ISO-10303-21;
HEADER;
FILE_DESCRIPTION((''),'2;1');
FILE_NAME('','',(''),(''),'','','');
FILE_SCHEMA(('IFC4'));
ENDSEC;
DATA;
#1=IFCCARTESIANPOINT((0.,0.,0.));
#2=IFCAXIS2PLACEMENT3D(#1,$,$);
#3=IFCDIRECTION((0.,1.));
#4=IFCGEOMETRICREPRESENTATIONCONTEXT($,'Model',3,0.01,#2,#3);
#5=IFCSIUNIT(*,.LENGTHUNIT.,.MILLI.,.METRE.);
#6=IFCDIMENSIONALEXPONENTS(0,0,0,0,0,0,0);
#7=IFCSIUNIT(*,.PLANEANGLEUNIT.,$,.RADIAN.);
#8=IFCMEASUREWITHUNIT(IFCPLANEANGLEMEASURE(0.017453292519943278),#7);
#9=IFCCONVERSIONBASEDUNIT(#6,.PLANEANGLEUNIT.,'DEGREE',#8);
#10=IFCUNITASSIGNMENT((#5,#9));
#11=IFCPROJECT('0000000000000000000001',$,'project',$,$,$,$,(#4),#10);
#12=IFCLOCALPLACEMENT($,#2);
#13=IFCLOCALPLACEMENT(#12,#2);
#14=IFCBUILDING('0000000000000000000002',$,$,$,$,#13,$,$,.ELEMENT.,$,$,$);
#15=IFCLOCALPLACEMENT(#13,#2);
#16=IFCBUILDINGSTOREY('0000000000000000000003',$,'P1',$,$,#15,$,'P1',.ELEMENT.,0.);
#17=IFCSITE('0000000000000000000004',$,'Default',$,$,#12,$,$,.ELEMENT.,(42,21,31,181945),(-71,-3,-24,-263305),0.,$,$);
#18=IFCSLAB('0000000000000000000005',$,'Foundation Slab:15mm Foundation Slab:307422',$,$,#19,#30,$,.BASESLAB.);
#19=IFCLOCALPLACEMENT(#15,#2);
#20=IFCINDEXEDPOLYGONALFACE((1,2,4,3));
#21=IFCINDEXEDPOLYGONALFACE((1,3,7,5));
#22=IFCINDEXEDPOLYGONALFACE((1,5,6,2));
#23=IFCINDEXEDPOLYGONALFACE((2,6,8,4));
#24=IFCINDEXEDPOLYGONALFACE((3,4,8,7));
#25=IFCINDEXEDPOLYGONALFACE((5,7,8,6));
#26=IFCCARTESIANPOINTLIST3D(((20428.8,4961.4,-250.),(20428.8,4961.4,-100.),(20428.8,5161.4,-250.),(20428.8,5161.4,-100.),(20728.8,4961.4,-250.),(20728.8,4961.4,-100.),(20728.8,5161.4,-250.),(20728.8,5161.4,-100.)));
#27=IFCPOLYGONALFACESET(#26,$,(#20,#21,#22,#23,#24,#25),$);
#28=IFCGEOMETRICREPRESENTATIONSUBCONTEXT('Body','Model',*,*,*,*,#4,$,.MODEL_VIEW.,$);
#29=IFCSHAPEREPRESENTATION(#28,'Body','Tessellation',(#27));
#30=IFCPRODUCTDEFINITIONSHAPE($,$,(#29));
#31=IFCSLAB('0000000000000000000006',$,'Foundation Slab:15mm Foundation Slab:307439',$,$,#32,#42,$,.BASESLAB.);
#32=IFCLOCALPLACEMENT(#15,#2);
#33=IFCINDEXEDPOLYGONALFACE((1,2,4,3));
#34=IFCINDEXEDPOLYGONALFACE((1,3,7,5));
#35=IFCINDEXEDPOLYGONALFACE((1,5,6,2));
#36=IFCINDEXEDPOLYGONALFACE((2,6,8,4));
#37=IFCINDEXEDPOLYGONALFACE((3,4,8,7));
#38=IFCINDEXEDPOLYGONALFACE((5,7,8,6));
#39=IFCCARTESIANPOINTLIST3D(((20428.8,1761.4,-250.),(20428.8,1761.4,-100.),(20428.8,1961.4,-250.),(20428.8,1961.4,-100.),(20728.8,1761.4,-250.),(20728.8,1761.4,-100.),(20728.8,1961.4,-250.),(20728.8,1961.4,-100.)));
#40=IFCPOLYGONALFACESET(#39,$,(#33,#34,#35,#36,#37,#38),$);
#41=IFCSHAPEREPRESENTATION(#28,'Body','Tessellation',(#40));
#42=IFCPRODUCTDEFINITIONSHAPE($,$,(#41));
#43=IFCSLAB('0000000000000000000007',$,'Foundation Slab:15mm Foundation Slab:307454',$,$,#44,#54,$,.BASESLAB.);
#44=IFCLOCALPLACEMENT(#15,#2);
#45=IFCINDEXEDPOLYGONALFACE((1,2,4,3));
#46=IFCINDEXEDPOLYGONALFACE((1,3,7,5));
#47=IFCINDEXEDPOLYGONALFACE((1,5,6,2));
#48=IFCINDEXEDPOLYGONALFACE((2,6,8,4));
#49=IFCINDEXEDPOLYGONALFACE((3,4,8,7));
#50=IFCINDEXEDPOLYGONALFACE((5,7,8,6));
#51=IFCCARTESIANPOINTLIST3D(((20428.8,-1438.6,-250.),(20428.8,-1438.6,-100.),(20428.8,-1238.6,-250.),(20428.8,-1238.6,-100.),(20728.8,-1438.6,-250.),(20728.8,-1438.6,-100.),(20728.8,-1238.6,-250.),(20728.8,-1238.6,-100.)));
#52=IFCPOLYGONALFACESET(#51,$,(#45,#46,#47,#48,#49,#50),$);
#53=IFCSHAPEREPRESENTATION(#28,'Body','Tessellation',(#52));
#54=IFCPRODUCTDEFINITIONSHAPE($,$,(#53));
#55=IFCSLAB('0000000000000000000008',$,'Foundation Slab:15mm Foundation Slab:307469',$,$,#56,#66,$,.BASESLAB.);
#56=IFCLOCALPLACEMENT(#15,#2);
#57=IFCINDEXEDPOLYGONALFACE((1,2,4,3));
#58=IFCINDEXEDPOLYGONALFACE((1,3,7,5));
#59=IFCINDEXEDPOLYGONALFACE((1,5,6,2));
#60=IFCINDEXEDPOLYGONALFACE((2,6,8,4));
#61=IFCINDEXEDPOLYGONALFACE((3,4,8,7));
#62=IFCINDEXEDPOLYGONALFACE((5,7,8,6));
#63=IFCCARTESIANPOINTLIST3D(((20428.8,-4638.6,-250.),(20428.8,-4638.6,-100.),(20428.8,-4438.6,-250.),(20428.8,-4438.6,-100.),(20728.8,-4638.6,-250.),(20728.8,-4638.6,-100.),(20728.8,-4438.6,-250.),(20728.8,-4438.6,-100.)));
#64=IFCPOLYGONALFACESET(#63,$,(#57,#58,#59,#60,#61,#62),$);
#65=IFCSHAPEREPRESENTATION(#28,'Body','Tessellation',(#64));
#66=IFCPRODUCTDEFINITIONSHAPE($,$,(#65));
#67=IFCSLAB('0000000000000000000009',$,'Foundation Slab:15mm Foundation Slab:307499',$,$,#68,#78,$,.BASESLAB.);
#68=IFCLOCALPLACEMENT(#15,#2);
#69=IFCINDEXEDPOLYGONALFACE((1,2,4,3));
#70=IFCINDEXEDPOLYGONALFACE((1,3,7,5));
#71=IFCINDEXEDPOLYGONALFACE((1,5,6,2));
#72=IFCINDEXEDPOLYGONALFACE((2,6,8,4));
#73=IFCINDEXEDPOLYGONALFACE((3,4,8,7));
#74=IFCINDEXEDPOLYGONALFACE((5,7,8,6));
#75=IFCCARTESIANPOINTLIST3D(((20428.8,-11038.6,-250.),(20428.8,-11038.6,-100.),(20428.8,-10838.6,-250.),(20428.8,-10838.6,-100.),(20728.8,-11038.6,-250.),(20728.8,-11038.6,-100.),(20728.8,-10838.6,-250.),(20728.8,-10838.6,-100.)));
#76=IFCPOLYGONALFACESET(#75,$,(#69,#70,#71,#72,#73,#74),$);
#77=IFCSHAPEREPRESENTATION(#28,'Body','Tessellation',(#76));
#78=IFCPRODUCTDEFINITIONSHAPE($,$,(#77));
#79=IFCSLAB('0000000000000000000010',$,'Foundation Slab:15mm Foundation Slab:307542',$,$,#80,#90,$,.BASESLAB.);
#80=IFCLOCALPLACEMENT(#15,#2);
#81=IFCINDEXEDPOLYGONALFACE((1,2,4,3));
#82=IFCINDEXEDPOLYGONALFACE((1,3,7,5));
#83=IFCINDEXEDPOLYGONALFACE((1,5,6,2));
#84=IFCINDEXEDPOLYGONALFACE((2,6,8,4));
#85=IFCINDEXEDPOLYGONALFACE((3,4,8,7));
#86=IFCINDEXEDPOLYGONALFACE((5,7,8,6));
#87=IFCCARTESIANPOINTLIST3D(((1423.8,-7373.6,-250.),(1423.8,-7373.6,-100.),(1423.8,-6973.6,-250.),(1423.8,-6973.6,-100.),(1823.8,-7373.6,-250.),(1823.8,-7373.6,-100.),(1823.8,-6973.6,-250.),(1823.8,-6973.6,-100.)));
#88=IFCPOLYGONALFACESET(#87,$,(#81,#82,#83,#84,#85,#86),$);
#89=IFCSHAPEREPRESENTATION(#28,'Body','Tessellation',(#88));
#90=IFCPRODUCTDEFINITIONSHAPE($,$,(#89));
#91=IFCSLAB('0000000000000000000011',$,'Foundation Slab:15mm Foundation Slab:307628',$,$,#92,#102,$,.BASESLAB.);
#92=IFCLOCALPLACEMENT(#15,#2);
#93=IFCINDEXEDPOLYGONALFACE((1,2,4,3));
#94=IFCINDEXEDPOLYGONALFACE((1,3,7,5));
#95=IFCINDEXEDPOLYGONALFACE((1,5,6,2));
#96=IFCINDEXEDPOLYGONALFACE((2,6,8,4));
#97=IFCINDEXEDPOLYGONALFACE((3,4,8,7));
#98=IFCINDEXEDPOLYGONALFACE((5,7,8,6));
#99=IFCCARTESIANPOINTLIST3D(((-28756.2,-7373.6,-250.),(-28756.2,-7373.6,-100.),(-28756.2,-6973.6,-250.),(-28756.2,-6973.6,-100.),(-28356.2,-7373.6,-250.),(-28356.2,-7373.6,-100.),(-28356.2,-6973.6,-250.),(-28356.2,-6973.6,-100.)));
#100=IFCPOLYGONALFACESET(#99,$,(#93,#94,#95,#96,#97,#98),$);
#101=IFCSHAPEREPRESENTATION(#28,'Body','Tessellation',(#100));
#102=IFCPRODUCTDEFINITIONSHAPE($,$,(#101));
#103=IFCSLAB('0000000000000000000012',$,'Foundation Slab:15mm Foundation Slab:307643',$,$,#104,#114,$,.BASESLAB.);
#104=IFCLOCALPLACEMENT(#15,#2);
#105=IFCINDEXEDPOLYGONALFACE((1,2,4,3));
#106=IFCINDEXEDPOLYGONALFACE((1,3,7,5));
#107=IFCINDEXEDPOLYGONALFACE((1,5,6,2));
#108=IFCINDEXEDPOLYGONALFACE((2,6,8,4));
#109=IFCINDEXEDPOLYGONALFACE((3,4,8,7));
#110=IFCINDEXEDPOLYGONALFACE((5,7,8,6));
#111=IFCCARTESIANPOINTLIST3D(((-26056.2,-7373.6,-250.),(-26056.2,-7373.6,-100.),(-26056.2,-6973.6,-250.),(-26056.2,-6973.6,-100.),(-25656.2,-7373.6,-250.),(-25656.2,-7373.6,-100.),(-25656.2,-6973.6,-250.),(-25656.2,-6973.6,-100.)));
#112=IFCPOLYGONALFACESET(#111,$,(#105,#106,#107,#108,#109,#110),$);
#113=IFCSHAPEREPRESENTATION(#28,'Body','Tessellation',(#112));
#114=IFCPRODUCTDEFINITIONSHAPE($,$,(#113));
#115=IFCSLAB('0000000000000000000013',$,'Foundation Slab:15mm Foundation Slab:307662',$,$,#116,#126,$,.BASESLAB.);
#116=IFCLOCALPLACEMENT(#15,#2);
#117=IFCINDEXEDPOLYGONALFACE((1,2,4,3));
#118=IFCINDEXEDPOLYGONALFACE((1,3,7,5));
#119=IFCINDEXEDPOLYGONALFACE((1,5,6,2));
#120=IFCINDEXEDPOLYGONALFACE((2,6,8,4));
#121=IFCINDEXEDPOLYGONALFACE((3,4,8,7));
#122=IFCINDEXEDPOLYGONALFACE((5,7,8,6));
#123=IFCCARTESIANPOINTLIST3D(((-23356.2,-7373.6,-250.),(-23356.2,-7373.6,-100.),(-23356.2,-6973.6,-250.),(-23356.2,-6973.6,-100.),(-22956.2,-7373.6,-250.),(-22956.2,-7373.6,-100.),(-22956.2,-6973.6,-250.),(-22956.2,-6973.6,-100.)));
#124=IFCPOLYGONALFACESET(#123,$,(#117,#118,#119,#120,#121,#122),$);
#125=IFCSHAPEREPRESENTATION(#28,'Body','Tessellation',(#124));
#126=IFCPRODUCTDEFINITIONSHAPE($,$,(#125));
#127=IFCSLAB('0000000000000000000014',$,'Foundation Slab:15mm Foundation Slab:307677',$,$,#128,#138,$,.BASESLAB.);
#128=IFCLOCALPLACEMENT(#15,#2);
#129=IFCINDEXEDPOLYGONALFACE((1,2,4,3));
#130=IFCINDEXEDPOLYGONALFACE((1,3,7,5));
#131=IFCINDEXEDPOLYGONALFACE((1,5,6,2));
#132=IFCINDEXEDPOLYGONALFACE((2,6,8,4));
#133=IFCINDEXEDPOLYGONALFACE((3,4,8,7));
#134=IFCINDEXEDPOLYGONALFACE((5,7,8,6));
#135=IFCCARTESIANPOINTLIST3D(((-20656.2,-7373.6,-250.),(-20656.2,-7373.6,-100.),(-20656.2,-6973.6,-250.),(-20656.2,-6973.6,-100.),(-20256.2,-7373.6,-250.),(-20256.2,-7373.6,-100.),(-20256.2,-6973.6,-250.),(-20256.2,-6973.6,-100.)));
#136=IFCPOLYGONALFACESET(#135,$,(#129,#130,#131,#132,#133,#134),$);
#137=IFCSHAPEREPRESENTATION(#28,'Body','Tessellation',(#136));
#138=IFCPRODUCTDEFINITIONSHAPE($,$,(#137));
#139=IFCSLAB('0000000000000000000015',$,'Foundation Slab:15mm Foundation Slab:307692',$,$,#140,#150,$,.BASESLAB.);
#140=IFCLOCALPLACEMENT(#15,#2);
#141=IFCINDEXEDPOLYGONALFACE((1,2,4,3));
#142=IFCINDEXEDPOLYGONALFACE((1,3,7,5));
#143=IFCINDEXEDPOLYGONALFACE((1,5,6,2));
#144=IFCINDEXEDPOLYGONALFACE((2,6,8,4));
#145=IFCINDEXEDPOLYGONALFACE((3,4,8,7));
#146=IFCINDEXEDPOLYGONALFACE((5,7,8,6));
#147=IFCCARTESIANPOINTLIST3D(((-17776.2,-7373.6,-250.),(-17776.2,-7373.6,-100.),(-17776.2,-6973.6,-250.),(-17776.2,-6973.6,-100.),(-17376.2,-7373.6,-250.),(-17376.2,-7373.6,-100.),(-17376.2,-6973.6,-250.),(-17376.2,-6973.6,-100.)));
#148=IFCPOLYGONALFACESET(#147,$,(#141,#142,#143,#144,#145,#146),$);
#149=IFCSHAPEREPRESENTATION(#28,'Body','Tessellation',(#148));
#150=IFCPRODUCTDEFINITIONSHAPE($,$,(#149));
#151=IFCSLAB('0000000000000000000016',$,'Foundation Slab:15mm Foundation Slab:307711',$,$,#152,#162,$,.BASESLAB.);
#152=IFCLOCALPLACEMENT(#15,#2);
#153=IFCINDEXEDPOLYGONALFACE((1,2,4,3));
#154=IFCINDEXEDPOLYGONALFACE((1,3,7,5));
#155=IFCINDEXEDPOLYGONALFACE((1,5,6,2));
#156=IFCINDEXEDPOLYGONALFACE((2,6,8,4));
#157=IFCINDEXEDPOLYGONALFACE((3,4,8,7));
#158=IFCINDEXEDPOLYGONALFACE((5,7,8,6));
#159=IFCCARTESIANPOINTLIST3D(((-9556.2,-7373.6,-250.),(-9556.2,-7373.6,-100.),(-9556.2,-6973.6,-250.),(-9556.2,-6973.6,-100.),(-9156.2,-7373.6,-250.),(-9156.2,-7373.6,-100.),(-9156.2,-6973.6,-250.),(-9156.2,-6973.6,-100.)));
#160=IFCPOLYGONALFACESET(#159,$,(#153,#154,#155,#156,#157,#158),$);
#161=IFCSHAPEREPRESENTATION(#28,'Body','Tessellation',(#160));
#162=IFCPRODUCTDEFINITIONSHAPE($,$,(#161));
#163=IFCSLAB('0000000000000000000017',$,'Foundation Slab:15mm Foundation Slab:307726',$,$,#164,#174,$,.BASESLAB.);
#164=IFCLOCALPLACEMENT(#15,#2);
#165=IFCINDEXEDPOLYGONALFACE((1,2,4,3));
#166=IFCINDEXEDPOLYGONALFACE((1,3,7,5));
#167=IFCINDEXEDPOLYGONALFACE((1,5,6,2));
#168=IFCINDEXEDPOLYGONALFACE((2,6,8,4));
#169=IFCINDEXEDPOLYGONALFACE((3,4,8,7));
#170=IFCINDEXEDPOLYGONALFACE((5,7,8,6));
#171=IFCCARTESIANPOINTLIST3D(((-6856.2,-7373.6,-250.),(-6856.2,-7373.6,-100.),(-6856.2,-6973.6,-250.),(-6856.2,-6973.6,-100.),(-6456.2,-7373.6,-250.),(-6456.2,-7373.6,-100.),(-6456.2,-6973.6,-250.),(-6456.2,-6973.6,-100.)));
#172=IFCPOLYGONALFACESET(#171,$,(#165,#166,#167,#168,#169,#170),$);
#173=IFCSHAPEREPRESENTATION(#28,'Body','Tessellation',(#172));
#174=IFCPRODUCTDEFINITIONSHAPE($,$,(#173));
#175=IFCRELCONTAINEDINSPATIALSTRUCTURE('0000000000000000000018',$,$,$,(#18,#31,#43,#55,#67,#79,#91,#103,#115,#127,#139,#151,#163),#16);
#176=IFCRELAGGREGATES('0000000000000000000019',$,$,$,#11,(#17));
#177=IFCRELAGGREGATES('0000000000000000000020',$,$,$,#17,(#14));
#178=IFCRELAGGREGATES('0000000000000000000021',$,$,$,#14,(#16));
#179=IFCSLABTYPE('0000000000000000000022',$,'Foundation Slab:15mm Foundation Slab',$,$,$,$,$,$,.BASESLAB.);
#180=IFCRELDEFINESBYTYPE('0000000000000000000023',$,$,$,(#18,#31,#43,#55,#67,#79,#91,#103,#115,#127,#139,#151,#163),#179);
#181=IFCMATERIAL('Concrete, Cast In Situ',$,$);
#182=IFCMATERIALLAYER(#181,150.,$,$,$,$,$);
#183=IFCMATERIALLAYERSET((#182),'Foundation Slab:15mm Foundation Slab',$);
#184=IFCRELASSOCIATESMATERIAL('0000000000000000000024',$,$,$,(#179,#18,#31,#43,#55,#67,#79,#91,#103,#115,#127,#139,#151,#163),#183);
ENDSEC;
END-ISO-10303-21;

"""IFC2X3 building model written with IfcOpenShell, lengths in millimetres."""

from ifc_helpers import new_model, entity, si_unit, converted_unit, direction, frame, frame_2d, origin, origin_2d_with_axis, place, context, subcontext, project, spatial, rectangle, extrude, material, layer, layer_set, layer_usage, type_object, element, save


model = new_model("IFC2X3")

# Units and contexts
model_context = context("Model", 3, precision=0.01, world=origin(), true_north=direction((0.0, 1.0)))
body_context = subcontext(model_context, "Body", "Model", "MODEL_VIEW")
ifc_project = project(units=[si_unit("LENGTHUNIT", "METRE", prefix="MILLI"), converted_unit("PLANEANGLEUNIT", "DEGREE", entity("IfcPlaneAngleMeasure", 0.017453292519943278), si_unit("PLANEANGLEUNIT", "RADIAN"), dimensions=[0, 0, 0, 0, 0, 0, 0])], contexts=[model_context])

# Site, building, storey
site_placement = place(None, origin())
site = spatial("IfcSite", under=ifc_project, at=site_placement, Name="Default", CompositionType="ELEMENT", RefLatitude=(42, 21, 31, 181945), RefLongitude=(-71, -3, -24, -263305), RefElevation=0.0)
building_placement = place(site_placement, origin())
building = spatial("IfcBuilding", under=site, at=building_placement, CompositionType="ELEMENT")
storey_placement = place(building_placement, origin())
storey = spatial("IfcBuildingStorey", under=building, at=storey_placement, Name="P1", LongName="P1", CompositionType="ELEMENT", Elevation=0.0)

# Slabs
ifc_material_1 = material(Name="Concrete, Cast In Situ")
ifc_layer_1 = layer(ifc_material_1, 150.0)
ifc_layer_set_1 = layer_set([ifc_layer_1], Name="Foundation Slab:15mm Foundation Slab")
ifc_layer_usage_1 = layer_usage(ifc_layer_set_1, "AXIS3", "POSITIVE", 0.0)
slab_type = type_object("IfcSlabType", Name="Foundation Slab:15mm Foundation Slab", PredefinedType="BASESLAB", material=ifc_layer_set_1)
slab_1_placement = place(storey_placement, origin())
element("IfcSlab", 1, at=slab_1_placement, inside=storey, type_object=slab_type, material=ifc_layer_usage_1, Name="Foundation Slab:15mm Foundation Slab:307422", PredefinedType="BASESLAB", context=body_context, shape_type="SweptSolid", body=[
    extrude(rectangle(XDim=200.0, YDim=300.0, at=origin_2d_with_axis()), frame((20578.8, 5061.4, -100.0), z_axis=(0.0, 0.0, -1.0), x_axis=(0.0, 1.0, 0.0)), (0.0, 0.0, 1.0), 150.0),
])
ifc_layer_usage_2 = layer_usage(ifc_layer_set_1, "AXIS3", "POSITIVE", 0.0)
slab_2_placement = place(storey_placement, origin())
element("IfcSlab", 2, at=slab_2_placement, inside=storey, type_object=slab_type, material=ifc_layer_usage_2, Name="Foundation Slab:15mm Foundation Slab:307439", PredefinedType="BASESLAB", context=body_context, shape_type="SweptSolid", body=[
    extrude(rectangle(XDim=200.0, YDim=300.0, at=origin_2d_with_axis()), frame((20578.8, 1861.4, -100.0), z_axis=(0.0, 0.0, -1.0), x_axis=(0.0, 1.0, 0.0)), (0.0, 0.0, 1.0), 150.0),
])
ifc_layer_usage_3 = layer_usage(ifc_layer_set_1, "AXIS3", "POSITIVE", 0.0)
slab_3_placement = place(storey_placement, origin())
element("IfcSlab", 3, at=slab_3_placement, inside=storey, type_object=slab_type, material=ifc_layer_usage_3, Name="Foundation Slab:15mm Foundation Slab:307454", PredefinedType="BASESLAB", context=body_context, shape_type="SweptSolid", body=[
    extrude(rectangle(XDim=200.0, YDim=300.0, at=origin_2d_with_axis()), frame((20578.8, -1338.6, -100.0), z_axis=(0.0, 0.0, -1.0), x_axis=(0.0, 1.0, 0.0)), (0.0, 0.0, 1.0), 150.0),
])
ifc_layer_usage_4 = layer_usage(ifc_layer_set_1, "AXIS3", "POSITIVE", 0.0)
slab_4_placement = place(storey_placement, origin())
element("IfcSlab", 4, at=slab_4_placement, inside=storey, type_object=slab_type, material=ifc_layer_usage_4, Name="Foundation Slab:15mm Foundation Slab:307469", PredefinedType="BASESLAB", context=body_context, shape_type="SweptSolid", body=[
    extrude(rectangle(XDim=200.0, YDim=300.0, at=origin_2d_with_axis()), frame((20578.8, -4538.6, -100.0), z_axis=(0.0, 0.0, -1.0), x_axis=(0.0, 1.0, 0.0)), (0.0, 0.0, 1.0), 150.0),
])
ifc_layer_usage_5 = layer_usage(ifc_layer_set_1, "AXIS3", "POSITIVE", 0.0)
slab_5_placement = place(storey_placement, origin())
element("IfcSlab", 5, at=slab_5_placement, inside=storey, type_object=slab_type, material=ifc_layer_usage_5, Name="Foundation Slab:15mm Foundation Slab:307499", PredefinedType="BASESLAB", context=body_context, shape_type="SweptSolid", body=[
    extrude(rectangle(XDim=200.0, YDim=300.0, at=frame_2d((0.0, 0.0), x_axis=(1.0, 0.0))), frame((20578.8, -10938.6, -100.0), z_axis=(0.0, 0.0, -1.0), x_axis=(0.0, 1.0, 0.0)), (0.0, 0.0, 1.0), 150.0),
])
ifc_layer_usage_6 = layer_usage(ifc_layer_set_1, "AXIS3", "POSITIVE", 0.0)
slab_6_placement = place(storey_placement, origin())
element("IfcSlab", 6, at=slab_6_placement, inside=storey, type_object=slab_type, material=ifc_layer_usage_6, Name="Foundation Slab:15mm Foundation Slab:307542", PredefinedType="BASESLAB", context=body_context, shape_type="SweptSolid", body=[
    extrude(rectangle(XDim=400.0, YDim=400.0, at=origin_2d_with_axis()), frame((1623.8, -7173.6, -100.0), z_axis=(0.0, 0.0, -1.0), x_axis=(0.0, 1.0, 0.0)), (0.0, 0.0, 1.0), 150.0),
])
ifc_layer_usage_7 = layer_usage(ifc_layer_set_1, "AXIS3", "POSITIVE", 0.0)
slab_7_placement = place(storey_placement, origin())
element("IfcSlab", 7, at=slab_7_placement, inside=storey, type_object=slab_type, material=ifc_layer_usage_7, Name="Foundation Slab:15mm Foundation Slab:307628", PredefinedType="BASESLAB", context=body_context, shape_type="SweptSolid", body=[
    extrude(rectangle(XDim=400.0, YDim=400.0, at=origin_2d_with_axis()), frame((-28556.2, -7173.6, -100.0), z_axis=(0.0, 0.0, -1.0), x_axis=(0.0, 1.0, 0.0)), (0.0, 0.0, 1.0), 150.0),
])
ifc_layer_usage_8 = layer_usage(ifc_layer_set_1, "AXIS3", "POSITIVE", 0.0)
slab_8_placement = place(storey_placement, origin())
element("IfcSlab", 8, at=slab_8_placement, inside=storey, type_object=slab_type, material=ifc_layer_usage_8, Name="Foundation Slab:15mm Foundation Slab:307643", PredefinedType="BASESLAB", context=body_context, shape_type="SweptSolid", body=[
    extrude(rectangle(XDim=400.0, YDim=400.0, at=origin_2d_with_axis()), frame((-25856.2, -7173.6, -100.0), z_axis=(0.0, 0.0, -1.0), x_axis=(0.0, 1.0, 0.0)), (0.0, 0.0, 1.0), 150.0),
])
ifc_layer_usage_9 = layer_usage(ifc_layer_set_1, "AXIS3", "POSITIVE", 0.0)
slab_9_placement = place(storey_placement, origin())
element("IfcSlab", 9, at=slab_9_placement, inside=storey, type_object=slab_type, material=ifc_layer_usage_9, Name="Foundation Slab:15mm Foundation Slab:307662", PredefinedType="BASESLAB", context=body_context, shape_type="SweptSolid", body=[
    extrude(rectangle(XDim=400.0, YDim=400.0, at=origin_2d_with_axis()), frame((-23156.2, -7173.6, -100.0), z_axis=(0.0, 0.0, -1.0), x_axis=(0.0, 1.0, 0.0)), (0.0, 0.0, 1.0), 150.0),
])
ifc_layer_usage_10 = layer_usage(ifc_layer_set_1, "AXIS3", "POSITIVE", 0.0)
slab_10_placement = place(storey_placement, origin())
element("IfcSlab", 10, at=slab_10_placement, inside=storey, type_object=slab_type, material=ifc_layer_usage_10, Name="Foundation Slab:15mm Foundation Slab:307677", PredefinedType="BASESLAB", context=body_context, shape_type="SweptSolid", body=[
    extrude(rectangle(XDim=400.0, YDim=400.0, at=origin_2d_with_axis()), frame((-20456.2, -7173.6, -100.0), z_axis=(0.0, 0.0, -1.0), x_axis=(0.0, 1.0, 0.0)), (0.0, 0.0, 1.0), 150.0),
])
ifc_layer_usage_11 = layer_usage(ifc_layer_set_1, "AXIS3", "POSITIVE", 0.0)
slab_11_placement = place(storey_placement, origin())
element("IfcSlab", 11, at=slab_11_placement, inside=storey, type_object=slab_type, material=ifc_layer_usage_11, Name="Foundation Slab:15mm Foundation Slab:307692", PredefinedType="BASESLAB", context=body_context, shape_type="SweptSolid", body=[
    extrude(rectangle(XDim=400.0, YDim=400.0, at=origin_2d_with_axis()), frame((-17576.2, -7173.6, -100.0), z_axis=(0.0, 0.0, -1.0), x_axis=(0.0, 1.0, 0.0)), (0.0, 0.0, 1.0), 150.0),
])
ifc_layer_usage_12 = layer_usage(ifc_layer_set_1, "AXIS3", "POSITIVE", 0.0)
slab_12_placement = place(storey_placement, origin())
element("IfcSlab", 12, at=slab_12_placement, inside=storey, type_object=slab_type, material=ifc_layer_usage_12, Name="Foundation Slab:15mm Foundation Slab:307711", PredefinedType="BASESLAB", context=body_context, shape_type="SweptSolid", body=[
    extrude(rectangle(XDim=400.0, YDim=400.0, at=origin_2d_with_axis()), frame((-9356.2, -7173.6, -100.0), z_axis=(0.0, 0.0, -1.0), x_axis=(0.0, 1.0, 0.0)), (0.0, 0.0, 1.0), 150.0),
])
ifc_layer_usage_13 = layer_usage(ifc_layer_set_1, "AXIS3", "POSITIVE", 0.0)
slab_13_placement = place(storey_placement, origin())
element("IfcSlab", 13, at=slab_13_placement, inside=storey, type_object=slab_type, material=ifc_layer_usage_13, Name="Foundation Slab:15mm Foundation Slab:307726", PredefinedType="BASESLAB", context=body_context, shape_type="SweptSolid", body=[
    extrude(rectangle(XDim=400.0, YDim=400.0, at=origin_2d_with_axis()), frame((-6656.2, -7173.6, -100.0), z_axis=(0.0, 0.0, -1.0), x_axis=(0.0, 1.0, 0.0)), (0.0, 0.0, 1.0), 150.0),
])

save(model, "model.ifc")
